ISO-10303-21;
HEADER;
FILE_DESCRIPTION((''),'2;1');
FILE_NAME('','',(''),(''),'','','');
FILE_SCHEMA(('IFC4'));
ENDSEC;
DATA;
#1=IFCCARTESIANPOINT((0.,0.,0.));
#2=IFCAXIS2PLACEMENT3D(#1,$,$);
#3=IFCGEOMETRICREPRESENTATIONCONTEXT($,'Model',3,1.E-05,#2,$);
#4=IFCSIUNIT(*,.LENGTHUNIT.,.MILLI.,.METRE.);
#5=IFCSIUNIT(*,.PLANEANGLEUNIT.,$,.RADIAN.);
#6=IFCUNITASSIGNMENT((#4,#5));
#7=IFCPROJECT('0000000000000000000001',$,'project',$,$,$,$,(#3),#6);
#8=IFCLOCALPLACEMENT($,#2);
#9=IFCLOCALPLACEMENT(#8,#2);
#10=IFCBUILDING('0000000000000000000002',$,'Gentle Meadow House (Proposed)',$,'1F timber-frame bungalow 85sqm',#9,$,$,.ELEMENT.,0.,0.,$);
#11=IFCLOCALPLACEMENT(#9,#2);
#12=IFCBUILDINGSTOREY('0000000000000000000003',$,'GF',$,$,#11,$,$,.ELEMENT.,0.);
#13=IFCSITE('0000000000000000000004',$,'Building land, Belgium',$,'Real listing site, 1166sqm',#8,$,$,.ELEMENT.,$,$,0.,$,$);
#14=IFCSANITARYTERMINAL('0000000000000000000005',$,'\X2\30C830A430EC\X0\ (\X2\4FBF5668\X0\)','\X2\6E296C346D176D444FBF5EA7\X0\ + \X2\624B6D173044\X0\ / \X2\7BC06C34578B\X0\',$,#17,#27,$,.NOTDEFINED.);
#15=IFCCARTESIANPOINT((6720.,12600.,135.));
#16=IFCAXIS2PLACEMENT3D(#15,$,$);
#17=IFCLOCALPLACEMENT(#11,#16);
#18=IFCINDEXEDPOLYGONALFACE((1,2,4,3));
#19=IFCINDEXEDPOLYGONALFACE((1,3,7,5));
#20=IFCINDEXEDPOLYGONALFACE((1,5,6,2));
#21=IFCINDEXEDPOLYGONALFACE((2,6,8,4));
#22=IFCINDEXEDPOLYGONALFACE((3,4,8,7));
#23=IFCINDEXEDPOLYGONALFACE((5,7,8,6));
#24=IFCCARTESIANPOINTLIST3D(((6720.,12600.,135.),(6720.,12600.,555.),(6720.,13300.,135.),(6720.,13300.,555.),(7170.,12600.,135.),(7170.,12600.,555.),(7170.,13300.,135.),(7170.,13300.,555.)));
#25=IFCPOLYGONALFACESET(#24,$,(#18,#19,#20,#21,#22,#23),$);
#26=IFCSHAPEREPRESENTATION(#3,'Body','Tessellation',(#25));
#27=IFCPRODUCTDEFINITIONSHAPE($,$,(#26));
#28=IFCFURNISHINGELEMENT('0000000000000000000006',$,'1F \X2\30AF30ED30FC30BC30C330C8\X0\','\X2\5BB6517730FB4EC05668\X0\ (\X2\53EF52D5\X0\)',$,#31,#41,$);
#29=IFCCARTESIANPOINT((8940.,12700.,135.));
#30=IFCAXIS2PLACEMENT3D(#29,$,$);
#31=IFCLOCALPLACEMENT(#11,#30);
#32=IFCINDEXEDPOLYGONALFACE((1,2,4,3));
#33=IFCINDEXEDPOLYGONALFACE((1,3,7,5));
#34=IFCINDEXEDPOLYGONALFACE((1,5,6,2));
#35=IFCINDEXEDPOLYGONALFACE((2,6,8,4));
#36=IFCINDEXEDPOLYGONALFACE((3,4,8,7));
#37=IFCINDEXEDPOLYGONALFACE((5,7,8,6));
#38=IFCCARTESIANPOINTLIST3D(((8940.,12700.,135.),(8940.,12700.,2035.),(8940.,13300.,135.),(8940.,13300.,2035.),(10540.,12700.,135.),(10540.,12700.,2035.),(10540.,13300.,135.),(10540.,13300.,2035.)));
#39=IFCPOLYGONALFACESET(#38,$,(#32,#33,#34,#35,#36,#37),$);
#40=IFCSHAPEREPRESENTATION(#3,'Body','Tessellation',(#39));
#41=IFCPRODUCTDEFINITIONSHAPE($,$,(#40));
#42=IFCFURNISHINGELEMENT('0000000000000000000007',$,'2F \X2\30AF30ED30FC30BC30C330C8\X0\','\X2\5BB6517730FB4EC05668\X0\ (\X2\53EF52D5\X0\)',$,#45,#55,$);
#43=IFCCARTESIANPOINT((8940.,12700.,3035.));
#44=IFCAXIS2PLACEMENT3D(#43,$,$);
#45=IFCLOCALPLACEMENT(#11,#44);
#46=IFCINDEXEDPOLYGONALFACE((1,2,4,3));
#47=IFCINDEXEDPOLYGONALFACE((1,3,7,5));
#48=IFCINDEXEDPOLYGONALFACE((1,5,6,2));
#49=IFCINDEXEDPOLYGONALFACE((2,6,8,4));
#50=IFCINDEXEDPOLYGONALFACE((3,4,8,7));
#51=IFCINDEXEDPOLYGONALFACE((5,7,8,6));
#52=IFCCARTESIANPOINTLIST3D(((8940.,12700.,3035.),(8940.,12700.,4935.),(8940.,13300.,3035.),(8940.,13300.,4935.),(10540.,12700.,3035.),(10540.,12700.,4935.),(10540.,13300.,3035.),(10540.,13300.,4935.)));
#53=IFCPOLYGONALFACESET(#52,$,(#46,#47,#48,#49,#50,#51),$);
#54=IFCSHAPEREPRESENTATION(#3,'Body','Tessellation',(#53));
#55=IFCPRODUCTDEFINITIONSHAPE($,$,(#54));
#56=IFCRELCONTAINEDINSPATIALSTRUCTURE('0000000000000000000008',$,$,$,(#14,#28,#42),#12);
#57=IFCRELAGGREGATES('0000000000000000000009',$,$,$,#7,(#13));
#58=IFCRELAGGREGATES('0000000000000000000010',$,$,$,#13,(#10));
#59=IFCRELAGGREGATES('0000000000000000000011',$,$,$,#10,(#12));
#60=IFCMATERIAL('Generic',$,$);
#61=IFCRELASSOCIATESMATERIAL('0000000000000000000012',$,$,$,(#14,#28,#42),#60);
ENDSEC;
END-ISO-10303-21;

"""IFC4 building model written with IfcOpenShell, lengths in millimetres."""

from ifc_helpers import new_model, si_unit, frame, frame_2d, origin, place, context, project, spatial, rectangle, extrude, material, element, save


model = new_model("IFC4")

# Units and contexts
model_context = context("Model", 3, precision=1e-05, world=origin())
ifc_project = project(units=[si_unit("LENGTHUNIT", "METRE", prefix="MILLI"), si_unit("PLANEANGLEUNIT", "RADIAN")], contexts=[model_context])

# Site, building, storey
site_placement = place(None, origin())
site = spatial("IfcSite", under=ifc_project, at=site_placement, Name="Building land, Belgium", ObjectType="Real listing site, 1166sqm", CompositionType="ELEMENT", RefElevation=0.0)
building_placement = place(site_placement, origin())
building = spatial("IfcBuilding", under=site, at=building_placement, Name="Gentle Meadow House (Proposed)", ObjectType="1F timber-frame bungalow 85sqm", CompositionType="ELEMENT", ElevationOfRefHeight=0.0, ElevationOfTerrain=0.0)
storey_placement = place(building_placement, origin())
storey = spatial("IfcBuildingStorey", under=building, at=storey_placement, Name="GF", CompositionType="ELEMENT", Elevation=0.0)

# Sanitary terminal
ifc_material_1 = material(Name="Generic")
sanitary_terminal_1_placement = place(storey_placement, frame((6720.0, 12600.0, 135.0)))
element("IfcSanitaryTerminal", 1, at=sanitary_terminal_1_placement, inside=storey, material=ifc_material_1, Name="トイレ (便器)", Description="温水洗浄便座 + 手洗い / 節水型", PredefinedType="NOTDEFINED", context=model_context, shape_type="SweptSolid", body=[
    extrude(rectangle(XDim=450.0, YDim=700.0, at=frame_2d((225.0, 350.0))), frame((6720.0, 12600.0, 135.0)), (0.0, 0.0, 1.0), 420.0),
])

# Furnishing elements
furnishing_1_placement = place(storey_placement, frame((8940.0, 12700.0, 135.0)))
element("IfcFurnishingElement", 2, at=furnishing_1_placement, inside=storey, material=ifc_material_1, Name="1F クローゼット", Description="家具・什器 (可動)", context=model_context, shape_type="SweptSolid", body=[
    extrude(rectangle(XDim=1600.0, YDim=600.0, at=frame_2d((800.0, 300.0))), frame((8940.0, 12700.0, 135.0)), (0.0, 0.0, 1.0), 1900.0),
])
furnishing_2_placement = place(storey_placement, frame((8940.0, 12700.0, 3035.0)))
element("IfcFurnishingElement", 3, at=furnishing_2_placement, inside=storey, material=ifc_material_1, Name="2F クローゼット", Description="家具・什器 (可動)", context=model_context, shape_type="SweptSolid", body=[
    extrude(rectangle(XDim=1600.0, YDim=600.0, at=frame_2d((800.0, 300.0))), frame((8940.0, 12700.0, 3035.0)), (0.0, 0.0, 1.0), 1900.0),
])

save(model, "model.ifc")
